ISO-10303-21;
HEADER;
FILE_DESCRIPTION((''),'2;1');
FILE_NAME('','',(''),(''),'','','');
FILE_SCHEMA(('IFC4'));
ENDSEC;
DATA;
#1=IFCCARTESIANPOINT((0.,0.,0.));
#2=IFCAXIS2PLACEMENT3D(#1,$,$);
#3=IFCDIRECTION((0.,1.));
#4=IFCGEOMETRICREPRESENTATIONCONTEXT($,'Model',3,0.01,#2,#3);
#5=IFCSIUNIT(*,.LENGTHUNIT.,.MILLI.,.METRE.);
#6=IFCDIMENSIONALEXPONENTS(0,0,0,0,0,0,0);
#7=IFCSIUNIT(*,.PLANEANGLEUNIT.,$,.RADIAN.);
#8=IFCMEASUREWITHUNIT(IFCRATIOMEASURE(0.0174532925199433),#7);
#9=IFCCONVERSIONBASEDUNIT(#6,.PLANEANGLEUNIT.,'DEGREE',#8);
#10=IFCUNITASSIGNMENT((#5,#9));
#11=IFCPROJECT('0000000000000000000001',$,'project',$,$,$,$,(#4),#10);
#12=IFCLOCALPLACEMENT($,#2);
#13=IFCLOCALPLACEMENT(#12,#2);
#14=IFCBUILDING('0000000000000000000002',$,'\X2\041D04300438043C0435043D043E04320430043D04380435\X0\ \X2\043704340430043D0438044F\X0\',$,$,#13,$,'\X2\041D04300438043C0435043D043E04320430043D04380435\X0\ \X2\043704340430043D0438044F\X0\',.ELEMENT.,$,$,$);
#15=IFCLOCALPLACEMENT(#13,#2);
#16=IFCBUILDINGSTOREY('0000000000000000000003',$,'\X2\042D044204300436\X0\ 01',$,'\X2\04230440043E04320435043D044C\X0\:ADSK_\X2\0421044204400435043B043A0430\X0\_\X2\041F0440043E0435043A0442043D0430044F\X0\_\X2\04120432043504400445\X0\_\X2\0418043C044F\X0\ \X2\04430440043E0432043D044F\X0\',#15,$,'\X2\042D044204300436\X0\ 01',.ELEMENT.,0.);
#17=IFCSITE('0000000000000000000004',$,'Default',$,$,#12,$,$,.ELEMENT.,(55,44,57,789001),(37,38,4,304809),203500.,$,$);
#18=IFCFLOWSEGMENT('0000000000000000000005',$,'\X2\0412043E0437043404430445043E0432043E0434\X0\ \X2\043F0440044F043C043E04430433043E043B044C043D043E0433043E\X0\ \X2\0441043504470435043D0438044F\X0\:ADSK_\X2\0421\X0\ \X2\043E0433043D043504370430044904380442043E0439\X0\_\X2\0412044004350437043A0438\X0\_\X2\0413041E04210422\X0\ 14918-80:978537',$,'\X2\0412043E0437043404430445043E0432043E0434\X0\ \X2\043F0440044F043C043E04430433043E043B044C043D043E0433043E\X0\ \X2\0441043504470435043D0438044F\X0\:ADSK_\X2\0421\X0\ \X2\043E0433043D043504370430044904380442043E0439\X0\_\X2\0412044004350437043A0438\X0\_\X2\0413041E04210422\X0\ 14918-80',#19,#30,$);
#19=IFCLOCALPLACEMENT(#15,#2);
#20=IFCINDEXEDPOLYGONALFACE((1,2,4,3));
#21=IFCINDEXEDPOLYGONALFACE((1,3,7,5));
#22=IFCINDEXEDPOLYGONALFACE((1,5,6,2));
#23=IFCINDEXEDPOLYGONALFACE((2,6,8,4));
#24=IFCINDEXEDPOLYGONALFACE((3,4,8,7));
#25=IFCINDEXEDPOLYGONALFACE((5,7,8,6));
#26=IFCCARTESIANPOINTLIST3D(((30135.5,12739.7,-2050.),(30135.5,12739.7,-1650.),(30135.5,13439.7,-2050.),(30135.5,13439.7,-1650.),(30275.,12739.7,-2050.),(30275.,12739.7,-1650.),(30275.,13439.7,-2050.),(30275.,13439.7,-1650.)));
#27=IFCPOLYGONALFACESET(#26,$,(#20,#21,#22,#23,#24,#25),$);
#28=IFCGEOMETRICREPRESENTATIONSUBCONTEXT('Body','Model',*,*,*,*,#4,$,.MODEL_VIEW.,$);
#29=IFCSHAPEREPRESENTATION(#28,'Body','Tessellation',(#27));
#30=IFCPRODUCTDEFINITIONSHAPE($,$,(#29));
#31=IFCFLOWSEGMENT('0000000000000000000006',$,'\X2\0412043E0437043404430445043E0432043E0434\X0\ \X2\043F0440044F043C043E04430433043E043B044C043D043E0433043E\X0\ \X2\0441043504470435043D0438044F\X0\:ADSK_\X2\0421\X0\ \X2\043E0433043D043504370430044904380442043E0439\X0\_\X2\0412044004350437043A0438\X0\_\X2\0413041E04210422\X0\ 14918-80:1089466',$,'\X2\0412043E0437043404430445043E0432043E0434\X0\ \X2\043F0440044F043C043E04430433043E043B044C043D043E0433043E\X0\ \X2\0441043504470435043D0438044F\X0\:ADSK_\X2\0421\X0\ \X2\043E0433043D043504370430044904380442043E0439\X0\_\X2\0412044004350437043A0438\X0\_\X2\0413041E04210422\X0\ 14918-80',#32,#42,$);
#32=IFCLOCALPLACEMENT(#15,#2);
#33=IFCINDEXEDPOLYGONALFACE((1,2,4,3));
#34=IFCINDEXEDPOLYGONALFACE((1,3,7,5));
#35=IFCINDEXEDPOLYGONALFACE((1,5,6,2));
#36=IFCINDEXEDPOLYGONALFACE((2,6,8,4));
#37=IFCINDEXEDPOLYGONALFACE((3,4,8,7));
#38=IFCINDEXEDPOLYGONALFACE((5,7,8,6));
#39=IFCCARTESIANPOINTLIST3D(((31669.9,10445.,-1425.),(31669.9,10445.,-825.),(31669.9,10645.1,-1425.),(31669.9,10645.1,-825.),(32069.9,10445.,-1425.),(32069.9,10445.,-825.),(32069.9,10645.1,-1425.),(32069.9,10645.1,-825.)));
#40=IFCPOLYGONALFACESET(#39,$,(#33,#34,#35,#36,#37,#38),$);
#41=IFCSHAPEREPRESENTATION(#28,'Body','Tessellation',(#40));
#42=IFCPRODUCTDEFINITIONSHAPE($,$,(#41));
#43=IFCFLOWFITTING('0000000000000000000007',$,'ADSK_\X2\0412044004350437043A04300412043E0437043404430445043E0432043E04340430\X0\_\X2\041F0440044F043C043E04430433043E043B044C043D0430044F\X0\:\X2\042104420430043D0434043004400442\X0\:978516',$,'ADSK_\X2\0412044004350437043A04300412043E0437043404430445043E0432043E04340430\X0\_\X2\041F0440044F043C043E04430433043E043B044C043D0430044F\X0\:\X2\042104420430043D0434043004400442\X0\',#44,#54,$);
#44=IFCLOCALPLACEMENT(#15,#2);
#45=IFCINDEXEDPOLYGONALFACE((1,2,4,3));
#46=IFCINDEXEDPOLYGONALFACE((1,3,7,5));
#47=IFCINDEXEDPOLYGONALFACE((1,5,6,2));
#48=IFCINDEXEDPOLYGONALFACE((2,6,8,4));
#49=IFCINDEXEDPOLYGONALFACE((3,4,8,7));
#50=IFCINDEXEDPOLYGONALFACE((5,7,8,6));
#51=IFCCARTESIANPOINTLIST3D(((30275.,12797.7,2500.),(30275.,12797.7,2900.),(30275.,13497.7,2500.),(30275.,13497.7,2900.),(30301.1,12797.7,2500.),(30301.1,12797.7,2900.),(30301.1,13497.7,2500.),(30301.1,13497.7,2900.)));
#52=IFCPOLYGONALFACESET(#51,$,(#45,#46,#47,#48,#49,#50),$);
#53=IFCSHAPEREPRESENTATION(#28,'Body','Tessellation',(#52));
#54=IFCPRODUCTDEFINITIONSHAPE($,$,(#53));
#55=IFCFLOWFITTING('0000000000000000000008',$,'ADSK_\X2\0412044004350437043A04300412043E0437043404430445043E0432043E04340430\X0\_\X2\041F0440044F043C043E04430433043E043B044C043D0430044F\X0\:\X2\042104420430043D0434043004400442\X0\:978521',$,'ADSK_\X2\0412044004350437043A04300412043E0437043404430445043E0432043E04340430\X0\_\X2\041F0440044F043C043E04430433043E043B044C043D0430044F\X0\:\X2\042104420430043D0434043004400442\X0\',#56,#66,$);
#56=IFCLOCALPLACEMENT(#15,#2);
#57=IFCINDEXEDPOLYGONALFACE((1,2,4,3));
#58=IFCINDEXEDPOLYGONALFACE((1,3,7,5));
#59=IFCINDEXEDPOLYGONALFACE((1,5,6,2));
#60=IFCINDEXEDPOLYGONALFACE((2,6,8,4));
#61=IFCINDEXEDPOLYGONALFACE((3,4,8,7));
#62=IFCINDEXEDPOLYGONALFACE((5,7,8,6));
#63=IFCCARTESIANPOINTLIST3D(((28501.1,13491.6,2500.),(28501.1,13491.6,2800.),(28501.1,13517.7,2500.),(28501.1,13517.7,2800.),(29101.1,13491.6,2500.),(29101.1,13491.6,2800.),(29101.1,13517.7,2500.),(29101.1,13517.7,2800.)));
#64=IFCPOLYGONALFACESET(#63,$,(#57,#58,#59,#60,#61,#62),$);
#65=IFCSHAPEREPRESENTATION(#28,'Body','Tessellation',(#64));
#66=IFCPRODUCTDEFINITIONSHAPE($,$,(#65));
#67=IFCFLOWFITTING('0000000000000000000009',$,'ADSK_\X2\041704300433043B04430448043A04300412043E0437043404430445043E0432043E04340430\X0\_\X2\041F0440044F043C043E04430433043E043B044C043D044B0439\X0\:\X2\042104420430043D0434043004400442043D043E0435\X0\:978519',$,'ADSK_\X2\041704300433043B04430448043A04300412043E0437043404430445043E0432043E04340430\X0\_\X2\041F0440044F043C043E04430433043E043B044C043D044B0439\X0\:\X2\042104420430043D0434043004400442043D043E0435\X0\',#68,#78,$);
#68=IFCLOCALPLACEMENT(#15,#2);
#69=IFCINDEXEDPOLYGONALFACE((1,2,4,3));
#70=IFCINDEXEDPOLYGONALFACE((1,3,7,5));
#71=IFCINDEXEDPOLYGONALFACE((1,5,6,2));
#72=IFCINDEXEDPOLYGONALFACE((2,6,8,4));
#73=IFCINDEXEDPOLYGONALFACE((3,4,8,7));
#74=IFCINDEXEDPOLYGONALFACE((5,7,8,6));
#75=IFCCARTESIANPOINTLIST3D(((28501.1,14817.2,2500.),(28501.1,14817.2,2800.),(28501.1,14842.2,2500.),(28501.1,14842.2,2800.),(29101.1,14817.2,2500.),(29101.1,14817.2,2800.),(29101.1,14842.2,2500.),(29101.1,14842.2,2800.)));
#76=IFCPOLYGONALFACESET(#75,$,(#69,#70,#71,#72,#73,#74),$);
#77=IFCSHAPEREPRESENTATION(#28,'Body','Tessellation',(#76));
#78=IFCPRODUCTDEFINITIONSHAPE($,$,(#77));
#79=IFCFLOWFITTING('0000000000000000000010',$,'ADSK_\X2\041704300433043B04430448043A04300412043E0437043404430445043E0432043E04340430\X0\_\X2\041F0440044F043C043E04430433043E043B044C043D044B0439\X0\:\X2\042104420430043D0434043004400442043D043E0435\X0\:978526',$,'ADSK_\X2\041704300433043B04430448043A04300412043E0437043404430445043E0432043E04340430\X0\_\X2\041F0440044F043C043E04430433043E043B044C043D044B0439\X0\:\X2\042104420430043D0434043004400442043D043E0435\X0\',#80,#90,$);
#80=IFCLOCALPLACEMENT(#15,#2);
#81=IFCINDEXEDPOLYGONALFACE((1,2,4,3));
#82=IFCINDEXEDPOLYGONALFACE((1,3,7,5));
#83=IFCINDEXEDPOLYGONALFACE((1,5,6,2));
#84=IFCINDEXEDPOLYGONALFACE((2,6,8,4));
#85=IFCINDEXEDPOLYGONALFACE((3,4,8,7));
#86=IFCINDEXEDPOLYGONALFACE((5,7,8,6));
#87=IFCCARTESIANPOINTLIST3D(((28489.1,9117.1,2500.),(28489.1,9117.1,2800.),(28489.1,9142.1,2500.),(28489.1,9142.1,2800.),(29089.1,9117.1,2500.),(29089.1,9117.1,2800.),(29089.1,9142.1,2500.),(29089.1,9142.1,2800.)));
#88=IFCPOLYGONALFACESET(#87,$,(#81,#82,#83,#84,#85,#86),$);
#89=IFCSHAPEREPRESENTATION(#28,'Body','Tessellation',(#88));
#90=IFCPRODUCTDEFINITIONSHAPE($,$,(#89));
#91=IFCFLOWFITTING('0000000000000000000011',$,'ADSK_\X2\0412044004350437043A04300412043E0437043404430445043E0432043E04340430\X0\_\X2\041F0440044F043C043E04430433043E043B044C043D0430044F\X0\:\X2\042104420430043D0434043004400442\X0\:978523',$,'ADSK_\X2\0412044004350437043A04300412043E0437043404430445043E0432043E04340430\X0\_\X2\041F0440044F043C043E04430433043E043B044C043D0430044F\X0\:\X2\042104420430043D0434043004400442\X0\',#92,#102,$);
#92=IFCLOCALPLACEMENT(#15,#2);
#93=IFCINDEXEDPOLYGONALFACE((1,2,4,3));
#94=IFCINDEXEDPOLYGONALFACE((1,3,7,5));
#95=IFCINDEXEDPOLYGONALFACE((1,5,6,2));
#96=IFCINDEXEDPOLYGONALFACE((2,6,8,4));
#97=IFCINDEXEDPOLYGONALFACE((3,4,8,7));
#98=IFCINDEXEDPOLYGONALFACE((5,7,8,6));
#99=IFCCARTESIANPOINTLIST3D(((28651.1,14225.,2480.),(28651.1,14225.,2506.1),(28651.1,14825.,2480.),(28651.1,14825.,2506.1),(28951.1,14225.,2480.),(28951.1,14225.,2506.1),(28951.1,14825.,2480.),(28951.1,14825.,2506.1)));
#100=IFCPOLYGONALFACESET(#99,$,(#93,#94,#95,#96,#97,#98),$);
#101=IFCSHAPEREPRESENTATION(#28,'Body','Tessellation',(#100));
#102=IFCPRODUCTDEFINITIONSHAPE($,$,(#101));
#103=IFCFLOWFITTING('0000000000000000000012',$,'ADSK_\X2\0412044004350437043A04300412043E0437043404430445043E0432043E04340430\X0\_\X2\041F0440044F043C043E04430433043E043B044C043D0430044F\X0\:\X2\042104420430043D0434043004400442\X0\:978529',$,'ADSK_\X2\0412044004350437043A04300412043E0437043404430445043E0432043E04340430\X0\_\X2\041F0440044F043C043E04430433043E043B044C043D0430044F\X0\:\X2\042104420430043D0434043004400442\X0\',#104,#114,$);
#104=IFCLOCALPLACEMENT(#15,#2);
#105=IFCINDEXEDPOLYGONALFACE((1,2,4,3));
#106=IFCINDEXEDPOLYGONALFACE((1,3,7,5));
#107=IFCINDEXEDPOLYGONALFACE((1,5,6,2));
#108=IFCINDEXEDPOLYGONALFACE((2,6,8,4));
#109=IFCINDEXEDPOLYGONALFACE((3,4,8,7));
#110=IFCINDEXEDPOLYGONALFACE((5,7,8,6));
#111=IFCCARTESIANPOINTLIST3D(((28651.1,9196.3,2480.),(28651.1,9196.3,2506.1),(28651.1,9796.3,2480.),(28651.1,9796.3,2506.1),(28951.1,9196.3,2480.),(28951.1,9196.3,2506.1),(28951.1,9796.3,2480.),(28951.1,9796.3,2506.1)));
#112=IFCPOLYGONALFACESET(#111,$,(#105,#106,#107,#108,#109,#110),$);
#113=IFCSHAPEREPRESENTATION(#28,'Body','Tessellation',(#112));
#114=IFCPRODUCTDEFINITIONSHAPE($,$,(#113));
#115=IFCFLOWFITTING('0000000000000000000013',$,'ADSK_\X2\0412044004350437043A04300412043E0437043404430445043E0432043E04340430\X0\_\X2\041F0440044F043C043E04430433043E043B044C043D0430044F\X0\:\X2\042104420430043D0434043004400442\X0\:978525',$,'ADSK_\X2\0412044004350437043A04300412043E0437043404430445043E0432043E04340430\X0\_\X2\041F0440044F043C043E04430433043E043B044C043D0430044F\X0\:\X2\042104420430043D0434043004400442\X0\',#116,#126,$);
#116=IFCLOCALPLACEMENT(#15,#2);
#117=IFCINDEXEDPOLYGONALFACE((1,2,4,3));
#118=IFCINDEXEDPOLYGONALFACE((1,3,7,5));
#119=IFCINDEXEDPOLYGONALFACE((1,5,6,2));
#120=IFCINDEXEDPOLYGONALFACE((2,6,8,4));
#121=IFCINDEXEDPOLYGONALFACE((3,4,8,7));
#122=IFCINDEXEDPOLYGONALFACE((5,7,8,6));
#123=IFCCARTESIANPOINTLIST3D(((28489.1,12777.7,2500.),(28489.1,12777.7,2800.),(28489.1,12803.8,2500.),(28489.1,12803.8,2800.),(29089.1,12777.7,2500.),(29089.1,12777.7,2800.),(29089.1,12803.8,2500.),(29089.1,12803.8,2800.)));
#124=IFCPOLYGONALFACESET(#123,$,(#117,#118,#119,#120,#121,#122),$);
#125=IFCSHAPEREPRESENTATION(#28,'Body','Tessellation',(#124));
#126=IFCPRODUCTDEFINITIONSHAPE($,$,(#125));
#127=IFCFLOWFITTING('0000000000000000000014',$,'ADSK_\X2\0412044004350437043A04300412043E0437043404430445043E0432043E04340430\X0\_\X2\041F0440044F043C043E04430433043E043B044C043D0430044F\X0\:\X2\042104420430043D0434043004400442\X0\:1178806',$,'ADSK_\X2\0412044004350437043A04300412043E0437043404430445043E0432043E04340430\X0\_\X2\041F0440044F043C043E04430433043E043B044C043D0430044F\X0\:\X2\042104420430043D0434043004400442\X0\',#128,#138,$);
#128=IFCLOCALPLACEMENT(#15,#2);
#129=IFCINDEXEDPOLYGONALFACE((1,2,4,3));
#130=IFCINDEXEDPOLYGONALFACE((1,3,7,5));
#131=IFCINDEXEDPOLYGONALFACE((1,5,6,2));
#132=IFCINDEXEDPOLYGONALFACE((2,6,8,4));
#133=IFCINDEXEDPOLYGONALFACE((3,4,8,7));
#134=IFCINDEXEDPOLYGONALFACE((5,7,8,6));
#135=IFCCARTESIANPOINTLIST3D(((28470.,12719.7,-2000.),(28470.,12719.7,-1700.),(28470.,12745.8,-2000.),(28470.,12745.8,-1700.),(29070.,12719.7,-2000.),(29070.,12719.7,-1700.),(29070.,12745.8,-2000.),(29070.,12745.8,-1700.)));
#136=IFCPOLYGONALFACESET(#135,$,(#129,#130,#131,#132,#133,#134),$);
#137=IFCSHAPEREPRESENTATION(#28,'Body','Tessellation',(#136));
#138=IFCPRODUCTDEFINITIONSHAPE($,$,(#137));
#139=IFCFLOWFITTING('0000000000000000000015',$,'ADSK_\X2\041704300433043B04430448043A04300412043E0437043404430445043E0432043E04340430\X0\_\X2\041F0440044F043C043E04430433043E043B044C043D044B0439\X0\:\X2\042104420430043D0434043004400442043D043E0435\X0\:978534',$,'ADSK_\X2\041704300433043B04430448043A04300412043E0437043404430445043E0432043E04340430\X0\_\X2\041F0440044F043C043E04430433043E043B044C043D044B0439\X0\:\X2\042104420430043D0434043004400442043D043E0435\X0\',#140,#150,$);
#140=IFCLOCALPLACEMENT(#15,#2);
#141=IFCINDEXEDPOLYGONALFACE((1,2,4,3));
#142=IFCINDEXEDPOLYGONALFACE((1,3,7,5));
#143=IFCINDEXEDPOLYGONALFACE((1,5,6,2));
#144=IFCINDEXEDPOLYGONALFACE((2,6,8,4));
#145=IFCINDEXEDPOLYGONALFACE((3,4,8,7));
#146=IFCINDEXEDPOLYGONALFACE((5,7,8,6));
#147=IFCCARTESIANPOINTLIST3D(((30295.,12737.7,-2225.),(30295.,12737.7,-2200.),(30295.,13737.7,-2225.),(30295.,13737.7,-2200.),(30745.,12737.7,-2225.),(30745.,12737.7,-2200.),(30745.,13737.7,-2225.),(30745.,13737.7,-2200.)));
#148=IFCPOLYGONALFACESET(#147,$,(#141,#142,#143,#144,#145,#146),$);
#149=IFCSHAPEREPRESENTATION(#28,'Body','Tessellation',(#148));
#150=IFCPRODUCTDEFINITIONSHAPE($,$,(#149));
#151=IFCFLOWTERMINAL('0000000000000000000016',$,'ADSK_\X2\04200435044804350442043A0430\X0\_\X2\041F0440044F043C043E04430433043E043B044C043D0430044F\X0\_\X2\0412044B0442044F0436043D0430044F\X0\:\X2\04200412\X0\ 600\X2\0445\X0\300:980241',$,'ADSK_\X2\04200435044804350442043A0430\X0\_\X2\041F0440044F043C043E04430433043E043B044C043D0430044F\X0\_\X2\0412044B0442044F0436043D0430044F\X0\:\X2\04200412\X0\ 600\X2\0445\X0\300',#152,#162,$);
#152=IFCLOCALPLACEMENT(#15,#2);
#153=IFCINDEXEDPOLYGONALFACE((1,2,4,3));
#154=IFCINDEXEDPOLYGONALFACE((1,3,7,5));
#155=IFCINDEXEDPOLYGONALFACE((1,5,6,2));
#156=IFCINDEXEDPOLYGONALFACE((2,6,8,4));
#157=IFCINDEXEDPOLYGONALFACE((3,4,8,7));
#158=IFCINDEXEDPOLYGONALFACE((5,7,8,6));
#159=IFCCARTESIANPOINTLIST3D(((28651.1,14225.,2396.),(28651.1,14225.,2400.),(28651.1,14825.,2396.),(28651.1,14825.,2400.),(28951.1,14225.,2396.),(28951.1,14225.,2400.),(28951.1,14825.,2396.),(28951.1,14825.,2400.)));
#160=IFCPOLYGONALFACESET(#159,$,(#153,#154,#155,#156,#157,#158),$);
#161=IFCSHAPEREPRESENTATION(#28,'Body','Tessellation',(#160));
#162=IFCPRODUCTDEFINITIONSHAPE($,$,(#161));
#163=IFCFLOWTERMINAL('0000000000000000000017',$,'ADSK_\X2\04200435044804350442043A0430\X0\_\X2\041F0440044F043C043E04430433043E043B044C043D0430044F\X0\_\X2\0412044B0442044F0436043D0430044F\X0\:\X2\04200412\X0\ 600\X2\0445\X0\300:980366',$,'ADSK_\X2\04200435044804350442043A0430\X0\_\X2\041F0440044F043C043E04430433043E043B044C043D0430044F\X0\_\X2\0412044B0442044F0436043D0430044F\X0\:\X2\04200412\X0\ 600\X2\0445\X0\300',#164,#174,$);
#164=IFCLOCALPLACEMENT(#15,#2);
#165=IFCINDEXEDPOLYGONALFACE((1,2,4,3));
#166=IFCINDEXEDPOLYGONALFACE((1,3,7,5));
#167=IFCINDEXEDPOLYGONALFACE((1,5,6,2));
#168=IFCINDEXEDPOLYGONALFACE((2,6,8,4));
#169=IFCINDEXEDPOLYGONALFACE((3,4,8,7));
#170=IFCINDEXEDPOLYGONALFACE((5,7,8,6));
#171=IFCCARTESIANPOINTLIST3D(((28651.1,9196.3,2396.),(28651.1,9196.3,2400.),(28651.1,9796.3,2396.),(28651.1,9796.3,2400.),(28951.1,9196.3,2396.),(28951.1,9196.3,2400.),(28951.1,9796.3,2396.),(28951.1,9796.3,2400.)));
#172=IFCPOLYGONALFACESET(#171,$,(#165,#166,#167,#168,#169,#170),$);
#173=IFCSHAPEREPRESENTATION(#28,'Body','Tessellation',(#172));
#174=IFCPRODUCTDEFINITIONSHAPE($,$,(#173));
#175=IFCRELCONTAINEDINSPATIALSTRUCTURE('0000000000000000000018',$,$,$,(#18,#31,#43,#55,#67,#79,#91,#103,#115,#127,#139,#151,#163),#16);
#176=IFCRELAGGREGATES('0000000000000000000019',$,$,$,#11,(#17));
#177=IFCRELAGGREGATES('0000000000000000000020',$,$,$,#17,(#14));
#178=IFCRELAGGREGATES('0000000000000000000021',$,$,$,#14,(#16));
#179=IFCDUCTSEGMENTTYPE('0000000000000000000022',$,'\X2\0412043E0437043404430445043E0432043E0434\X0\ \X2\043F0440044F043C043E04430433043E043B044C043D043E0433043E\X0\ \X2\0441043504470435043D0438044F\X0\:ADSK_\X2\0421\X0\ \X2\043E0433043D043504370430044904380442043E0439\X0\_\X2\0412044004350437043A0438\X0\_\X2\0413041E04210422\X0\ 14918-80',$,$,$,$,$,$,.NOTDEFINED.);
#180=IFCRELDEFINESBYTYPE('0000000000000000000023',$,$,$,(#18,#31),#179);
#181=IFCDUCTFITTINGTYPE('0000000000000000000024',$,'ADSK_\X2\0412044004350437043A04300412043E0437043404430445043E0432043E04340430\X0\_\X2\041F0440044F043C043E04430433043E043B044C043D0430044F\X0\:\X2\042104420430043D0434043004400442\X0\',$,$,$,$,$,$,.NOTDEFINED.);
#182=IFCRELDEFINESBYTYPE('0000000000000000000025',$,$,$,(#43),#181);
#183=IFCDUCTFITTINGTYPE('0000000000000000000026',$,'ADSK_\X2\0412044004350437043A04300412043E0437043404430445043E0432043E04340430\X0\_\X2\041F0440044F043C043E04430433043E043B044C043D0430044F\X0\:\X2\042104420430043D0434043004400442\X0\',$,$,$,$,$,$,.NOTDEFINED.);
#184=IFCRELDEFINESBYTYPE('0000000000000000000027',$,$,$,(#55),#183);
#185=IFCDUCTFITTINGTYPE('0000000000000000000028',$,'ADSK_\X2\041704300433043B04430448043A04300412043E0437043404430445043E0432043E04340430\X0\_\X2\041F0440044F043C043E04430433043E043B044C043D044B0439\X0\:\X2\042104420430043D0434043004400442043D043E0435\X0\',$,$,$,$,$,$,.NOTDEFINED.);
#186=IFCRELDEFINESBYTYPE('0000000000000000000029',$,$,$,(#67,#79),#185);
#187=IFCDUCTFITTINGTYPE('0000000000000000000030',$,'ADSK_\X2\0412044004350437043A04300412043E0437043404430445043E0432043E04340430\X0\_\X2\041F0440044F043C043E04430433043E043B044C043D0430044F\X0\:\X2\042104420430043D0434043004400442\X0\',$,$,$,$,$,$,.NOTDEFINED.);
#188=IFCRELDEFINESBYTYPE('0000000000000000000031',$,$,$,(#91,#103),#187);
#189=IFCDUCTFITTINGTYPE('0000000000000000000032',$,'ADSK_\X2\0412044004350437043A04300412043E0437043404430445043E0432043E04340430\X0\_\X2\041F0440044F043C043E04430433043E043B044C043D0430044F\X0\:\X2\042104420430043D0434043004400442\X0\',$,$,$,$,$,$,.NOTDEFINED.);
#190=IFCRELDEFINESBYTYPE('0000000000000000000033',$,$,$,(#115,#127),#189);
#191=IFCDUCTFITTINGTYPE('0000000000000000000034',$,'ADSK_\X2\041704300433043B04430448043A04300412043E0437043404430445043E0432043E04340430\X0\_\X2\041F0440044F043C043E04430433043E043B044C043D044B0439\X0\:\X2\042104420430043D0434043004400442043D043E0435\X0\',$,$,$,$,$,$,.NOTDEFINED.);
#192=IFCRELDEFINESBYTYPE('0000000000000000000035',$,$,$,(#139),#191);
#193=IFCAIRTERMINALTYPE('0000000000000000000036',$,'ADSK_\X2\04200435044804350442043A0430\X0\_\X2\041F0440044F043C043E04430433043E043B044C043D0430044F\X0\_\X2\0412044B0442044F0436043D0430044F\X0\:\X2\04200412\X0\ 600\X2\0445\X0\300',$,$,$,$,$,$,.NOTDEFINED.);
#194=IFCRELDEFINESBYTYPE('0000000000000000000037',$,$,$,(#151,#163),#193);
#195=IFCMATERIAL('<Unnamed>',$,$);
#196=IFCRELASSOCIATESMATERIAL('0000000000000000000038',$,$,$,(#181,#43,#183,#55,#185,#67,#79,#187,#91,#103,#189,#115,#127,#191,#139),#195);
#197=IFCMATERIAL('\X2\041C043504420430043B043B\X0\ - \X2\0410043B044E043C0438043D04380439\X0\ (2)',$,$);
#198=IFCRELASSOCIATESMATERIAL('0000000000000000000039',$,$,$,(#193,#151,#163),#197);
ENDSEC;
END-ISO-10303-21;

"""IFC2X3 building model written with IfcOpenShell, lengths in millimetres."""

from ifc_helpers import new_model, entity, si_unit, converted_unit, direction, frame, frame_2d, origin, origin_2d_with_axis, place, context, subcontext, project, spatial, rectangle, extrude, source, transform, mapped, material, type_object, type_shapes, element, save


model = new_model("IFC2X3")

# Units and contexts
model_context = context("Model", 3, precision=0.01, world=origin(), true_north=direction((0.0, 1.0)))
body_context = subcontext(model_context, "Body", "Model", "MODEL_VIEW")
ifc_project = project(units=[si_unit("LENGTHUNIT", "METRE", prefix="MILLI"), converted_unit("PLANEANGLEUNIT", "DEGREE", entity("IfcRatioMeasure", 0.0174532925199433), si_unit("PLANEANGLEUNIT", "RADIAN"), dimensions=[0, 0, 0, 0, 0, 0, 0])], contexts=[model_context])

# Site, building, storey
site_placement = place(None, frame((0.0, 0.0, 0.0)))
site = spatial("IfcSite", under=ifc_project, at=site_placement, Name="Default", CompositionType="ELEMENT", RefLatitude=(55, 44, 57, 789001), RefLongitude=(37, 38, 4, 304809), RefElevation=203500.0)
building_placement = place(site_placement, origin())
building = spatial("IfcBuilding", under=site, at=building_placement, Name="Наименование здания", LongName="Наименование здания", CompositionType="ELEMENT")
storey_placement = place(building_placement, origin())
storey = spatial("IfcBuildingStorey", under=building, at=storey_placement, Name="Этаж 01", ObjectType="Уровень:ADSK_Стрелка_Проектная_Вверх_Имя уровня", LongName="Этаж 01", CompositionType="ELEMENT", Elevation=0.0)

# Flow segments
duct_segment_type = type_object("IfcDuctSegmentType", Name="Воздуховод прямоугольного сечения:ADSK_С огнезащитой_Врезки_ГОСТ 14918-80", PredefinedType="NOTDEFINED")
flow_segment_1_placement = place(storey_placement, frame((30135.5, 12739.7, -2050.0)))
element("IfcFlowSegment", 1, at=flow_segment_1_placement, inside=storey, type_object=duct_segment_type, Name="Воздуховод прямоугольного сечения:ADSK_С огнезащитой_Врезки_ГОСТ 14918-80:978537", ObjectType="Воздуховод прямоугольного сечения:ADSK_С огнезащитой_Врезки_ГОСТ 14918-80", context=body_context, shape_type="SweptSolid", body=[
    extrude(rectangle(XDim=139.5, YDim=700.0, at=frame_2d((0.0, 0.0), x_axis=(1.0, 0.0))), frame((69.7, 350.0, 0.0)), (0.0, 0.0, 1.0), 400.0),
])
flow_segment_2_placement = place(storey_placement, frame((31669.9, 10445.0, -1425.0)))
element("IfcFlowSegment", 2, at=flow_segment_2_placement, inside=storey, type_object=duct_segment_type, Name="Воздуховод прямоугольного сечения:ADSK_С огнезащитой_Врезки_ГОСТ 14918-80:1089466", ObjectType="Воздуховод прямоугольного сечения:ADSK_С огнезащитой_Врезки_ГОСТ 14918-80", context=body_context, shape_type="SweptSolid", body=[
    extrude(rectangle(XDim=200.1, YDim=400.0, at=frame_2d((0.0, 0.0), x_axis=(1.0, 0.0))), frame((200.0, 100.0, 0.0), z_axis=(0.0, 0.0, 1.0), x_axis=(0.0, 1.0, 0.0)), (0.0, 0.0, 1.0), 600.0),
])

# Flow fittings
ifc_material_1 = material(Name="<Unnamed>")
duct_fitting_type_1 = type_object("IfcDuctFittingType", Name="ADSK_ВрезкаВоздуховода_Прямоугольная:Стандарт", PredefinedType="NOTDEFINED", material=ifc_material_1)
shared_shape_1 = source(origin(), body_context, "Body", "SweptSolid", [
    extrude(rectangle(XDim=26.1, YDim=400.0, at=frame_2d((0.0, 0.0), x_axis=(1.0, 0.0))), frame((7.0, 0.0, -350.0)), (0.0, 0.0, 1.0), 700.0),
])
type_shapes(duct_fitting_type_1, [shared_shape_1])
flow_fitting_1_placement = place(storey_placement, frame((30295.0, 13147.7, 2700.0), z_axis=(0.0, 1.0, 0.0), x_axis=(-1.0, 0.0, 0.0)))
element("IfcFlowFitting", 3, at=flow_fitting_1_placement, inside=storey, type_object=duct_fitting_type_1, material=ifc_material_1, Name="ADSK_ВрезкаВоздуховода_Прямоугольная:Стандарт:978516", ObjectType="ADSK_ВрезкаВоздуховода_Прямоугольная:Стандарт", context=body_context, shape_type="MappedRepresentation", body=[
    mapped(shared_shape_1, transform((0.0, 0.0, 0.0), scale=1.0)),
])
duct_fitting_type_2 = type_object("IfcDuctFittingType", Name="ADSK_ВрезкаВоздуховода_Прямоугольная:Стандарт", PredefinedType="NOTDEFINED", material=ifc_material_1)
shared_shape_2 = source(origin(), body_context, "Body", "SweptSolid", [
    extrude(rectangle(XDim=26.1, YDim=600.0, at=frame_2d((0.0, 0.0), x_axis=(1.0, 0.0))), frame((7.0, 0.0, -150.0)), (0.0, 0.0, 1.0), 300.0),
])
type_shapes(duct_fitting_type_2, [shared_shape_2])
flow_fitting_2_placement = place(storey_placement, frame((28801.1, 13497.7, 2650.0), z_axis=(0.0, 0.0, -1.0), x_axis=(0.0, 1.0, 0.0)))
element("IfcFlowFitting", 4, at=flow_fitting_2_placement, inside=storey, type_object=duct_fitting_type_2, material=ifc_material_1, Name="ADSK_ВрезкаВоздуховода_Прямоугольная:Стандарт:978521", ObjectType="ADSK_ВрезкаВоздуховода_Прямоугольная:Стандарт", context=body_context, shape_type="MappedRepresentation", body=[
    mapped(shared_shape_2, transform((0.0, 0.0, 0.0), scale=1.0)),
])
duct_fitting_type_3 = type_object("IfcDuctFittingType", Name="ADSK_ЗаглушкаВоздуховода_Прямоугольный:Стандартное", PredefinedType="NOTDEFINED", material=ifc_material_1)
shared_shape_3 = source(origin(), body_context, "Body", "SweptSolid", [
    extrude(rectangle(XDim=25.0, YDim=600.0, at=frame_2d((0.0, 0.0), x_axis=(1.0, 0.0))), frame((12.5, 0.0, -150.0)), (0.0, 0.0, 1.0), 300.0),
])
type_shapes(duct_fitting_type_3, [shared_shape_3])
for number, where, z_axis, x_axis, name in (
    (5, (28801.1, 14817.2, 2650.0), (0.0, 0.0, 1.0), (0.0, 1.0, 0.0), "ADSK_ЗаглушкаВоздуховода_Прямоугольный:Стандартное:978519"),
    (6, (28789.1, 9142.1, 2650.0), (0.0, 0.0, 1.0), (0.0, -1.0, 0.0), "ADSK_ЗаглушкаВоздуховода_Прямоугольный:Стандартное:978526"),
):
    element("IfcFlowFitting", number, at=place(storey_placement, frame(where, z_axis=z_axis, x_axis=x_axis)), inside=storey, type_object=duct_fitting_type_3, material=ifc_material_1, Name=name, ObjectType="ADSK_ЗаглушкаВоздуховода_Прямоугольный:Стандартное", context=body_context, shape_type="MappedRepresentation", body=[
        mapped(shared_shape_3, transform((0.0, 0.0, 0.0), scale=1.0)),
    ])
duct_fitting_type_4 = type_object("IfcDuctFittingType", Name="ADSK_ВрезкаВоздуховода_Прямоугольная:Стандарт", PredefinedType="NOTDEFINED", material=ifc_material_1)
shared_shape_4 = source(origin(), body_context, "Body", "SweptSolid", [
    extrude(rectangle(XDim=300.0, YDim=26.1, at=frame_2d((0.0, 0.0), x_axis=(1.0, 0.0))), frame((7.0, 0.0, -300.0), z_axis=(0.0, 0.0, 1.0), x_axis=(0.0, -1.0, 0.0)), (0.0, 0.0, 1.0), 600.0),
])
type_shapes(duct_fitting_type_4, [shared_shape_4])
for number, where, z_axis, x_axis, name in (
    (7, (28801.1, 14525.0, 2500.0), (0.0, 1.0, 0.0), (0.0, 0.0, -1.0), "ADSK_ВрезкаВоздуховода_Прямоугольная:Стандарт:978523"),
    (8, (28801.1, 9496.3, 2500.0), (0.0, 1.0, 0.0), (0.0, 0.0, -1.0), "ADSK_ВрезкаВоздуховода_Прямоугольная:Стандарт:978529"),
):
    element("IfcFlowFitting", number, at=place(storey_placement, frame(where, z_axis=z_axis, x_axis=x_axis)), inside=storey, type_object=duct_fitting_type_4, material=ifc_material_1, Name=name, ObjectType="ADSK_ВрезкаВоздуховода_Прямоугольная:Стандарт", context=body_context, shape_type="MappedRepresentation", body=[
        mapped(shared_shape_4, transform((0.0, 0.0, 0.0), scale=1.0)),
    ])
duct_fitting_type_5 = type_object("IfcDuctFittingType", Name="ADSK_ВрезкаВоздуховода_Прямоугольная:Стандарт", PredefinedType="NOTDEFINED", material=ifc_material_1)
shared_shape_5 = source(origin(), body_context, "Body", "SweptSolid", [
    extrude(rectangle(XDim=600.0, YDim=26.1, at=origin_2d_with_axis()), frame((7.0, 0.0, -150.0), z_axis=(0.0, 0.0, 1.0), x_axis=(0.0, -1.0, 0.0)), (0.0, 0.0, 1.0), 300.0),
])
type_shapes(duct_fitting_type_5, [shared_shape_5])
for number, where, z_axis, x_axis, name in (
    (9, (28789.1, 12797.7, 2650.0), (0.0, 0.0, -1.0), (0.0, -1.0, 0.0), "ADSK_ВрезкаВоздуховода_Прямоугольная:Стандарт:978525"),
    (10, (28770.0, 12739.7, -1850.0), (0.0, 0.0, -1.0), (0.0, -1.0, 0.0), "ADSK_ВрезкаВоздуховода_Прямоугольная:Стандарт:1178806"),
):
    element("IfcFlowFitting", number, at=place(storey_placement, frame(where, z_axis=z_axis, x_axis=x_axis)), inside=storey, type_object=duct_fitting_type_5, material=ifc_material_1, Name=name, ObjectType="ADSK_ВрезкаВоздуховода_Прямоугольная:Стандарт", context=body_context, shape_type="MappedRepresentation", body=[
        mapped(shared_shape_5, transform((0.0, 0.0, 0.0), scale=1.0)),
    ])
duct_fitting_type_6 = type_object("IfcDuctFittingType", Name="ADSK_ЗаглушкаВоздуховода_Прямоугольный:Стандартное", PredefinedType="NOTDEFINED", material=ifc_material_1)
shared_shape_6 = source(origin(), body_context, "Body", "SweptSolid", [
    extrude(rectangle(XDim=25.0, YDim=1000.0, at=frame_2d((0.0, 0.0), x_axis=(1.0, 0.0))), frame((12.5, 0.0, -225.0)), (0.0, 0.0, 1.0), 450.0),
])
type_shapes(duct_fitting_type_6, [shared_shape_6])
flow_fitting_3_placement = place(storey_placement, frame((30520.0, 13237.7, -2200.0), z_axis=(-1.0, 0.0, 0.0), x_axis=(0.0, 0.0, -1.0)))
element("IfcFlowFitting", 11, at=flow_fitting_3_placement, inside=storey, type_object=duct_fitting_type_6, material=ifc_material_1, Name="ADSK_ЗаглушкаВоздуховода_Прямоугольный:Стандартное:978534", ObjectType="ADSK_ЗаглушкаВоздуховода_Прямоугольный:Стандартное", context=body_context, shape_type="MappedRepresentation", body=[
    mapped(shared_shape_6, transform((0.0, 0.0, 0.0), scale=1.0)),
])

# Flow terminals
ifc_material_2 = material(Name="Металл - Алюминий (2)")
air_terminal_type = type_object("IfcAirTerminalType", Name="ADSK_Решетка_Прямоугольная_Вытяжная:РВ 600х300", PredefinedType="NOTDEFINED", material=ifc_material_2)
shared_shape_7 = source(origin(), body_context, "Body", "SweptSolid", [
    extrude(rectangle(XDim=4.0, YDim=600.0, at=origin_2d_with_axis()), frame((0.0, -2.0, -150.0), z_axis=(0.0, 0.0, 1.0), x_axis=(0.0, 1.0, 0.0)), (0.0, 0.0, 1.0), 300.0),
])
type_shapes(air_terminal_type, [shared_shape_7])
for number, where, z_axis, x_axis, name in (
    (12, (28801.1, 14525.0, 2400.0), (-1.0, 0.0, 0.0), (0.0, -1.0, 0.0), "ADSK_Решетка_Прямоугольная_Вытяжная:РВ 600х300:980241"),
    (13, (28801.1, 9496.3, 2400.0), (-1.0, 0.0, 0.0), (0.0, -1.0, 0.0), "ADSK_Решетка_Прямоугольная_Вытяжная:РВ 600х300:980366"),
):
    element("IfcFlowTerminal", number, at=place(storey_placement, frame(where, z_axis=z_axis, x_axis=x_axis)), inside=storey, type_object=air_terminal_type, material=ifc_material_2, Name=name, ObjectType="ADSK_Решетка_Прямоугольная_Вытяжная:РВ 600х300", context=body_context, shape_type="MappedRepresentation", body=[
        mapped(shared_shape_7, transform((0.0, 0.0, 0.0), scale=1.0)),
    ])

save(model, "model.ifc")
